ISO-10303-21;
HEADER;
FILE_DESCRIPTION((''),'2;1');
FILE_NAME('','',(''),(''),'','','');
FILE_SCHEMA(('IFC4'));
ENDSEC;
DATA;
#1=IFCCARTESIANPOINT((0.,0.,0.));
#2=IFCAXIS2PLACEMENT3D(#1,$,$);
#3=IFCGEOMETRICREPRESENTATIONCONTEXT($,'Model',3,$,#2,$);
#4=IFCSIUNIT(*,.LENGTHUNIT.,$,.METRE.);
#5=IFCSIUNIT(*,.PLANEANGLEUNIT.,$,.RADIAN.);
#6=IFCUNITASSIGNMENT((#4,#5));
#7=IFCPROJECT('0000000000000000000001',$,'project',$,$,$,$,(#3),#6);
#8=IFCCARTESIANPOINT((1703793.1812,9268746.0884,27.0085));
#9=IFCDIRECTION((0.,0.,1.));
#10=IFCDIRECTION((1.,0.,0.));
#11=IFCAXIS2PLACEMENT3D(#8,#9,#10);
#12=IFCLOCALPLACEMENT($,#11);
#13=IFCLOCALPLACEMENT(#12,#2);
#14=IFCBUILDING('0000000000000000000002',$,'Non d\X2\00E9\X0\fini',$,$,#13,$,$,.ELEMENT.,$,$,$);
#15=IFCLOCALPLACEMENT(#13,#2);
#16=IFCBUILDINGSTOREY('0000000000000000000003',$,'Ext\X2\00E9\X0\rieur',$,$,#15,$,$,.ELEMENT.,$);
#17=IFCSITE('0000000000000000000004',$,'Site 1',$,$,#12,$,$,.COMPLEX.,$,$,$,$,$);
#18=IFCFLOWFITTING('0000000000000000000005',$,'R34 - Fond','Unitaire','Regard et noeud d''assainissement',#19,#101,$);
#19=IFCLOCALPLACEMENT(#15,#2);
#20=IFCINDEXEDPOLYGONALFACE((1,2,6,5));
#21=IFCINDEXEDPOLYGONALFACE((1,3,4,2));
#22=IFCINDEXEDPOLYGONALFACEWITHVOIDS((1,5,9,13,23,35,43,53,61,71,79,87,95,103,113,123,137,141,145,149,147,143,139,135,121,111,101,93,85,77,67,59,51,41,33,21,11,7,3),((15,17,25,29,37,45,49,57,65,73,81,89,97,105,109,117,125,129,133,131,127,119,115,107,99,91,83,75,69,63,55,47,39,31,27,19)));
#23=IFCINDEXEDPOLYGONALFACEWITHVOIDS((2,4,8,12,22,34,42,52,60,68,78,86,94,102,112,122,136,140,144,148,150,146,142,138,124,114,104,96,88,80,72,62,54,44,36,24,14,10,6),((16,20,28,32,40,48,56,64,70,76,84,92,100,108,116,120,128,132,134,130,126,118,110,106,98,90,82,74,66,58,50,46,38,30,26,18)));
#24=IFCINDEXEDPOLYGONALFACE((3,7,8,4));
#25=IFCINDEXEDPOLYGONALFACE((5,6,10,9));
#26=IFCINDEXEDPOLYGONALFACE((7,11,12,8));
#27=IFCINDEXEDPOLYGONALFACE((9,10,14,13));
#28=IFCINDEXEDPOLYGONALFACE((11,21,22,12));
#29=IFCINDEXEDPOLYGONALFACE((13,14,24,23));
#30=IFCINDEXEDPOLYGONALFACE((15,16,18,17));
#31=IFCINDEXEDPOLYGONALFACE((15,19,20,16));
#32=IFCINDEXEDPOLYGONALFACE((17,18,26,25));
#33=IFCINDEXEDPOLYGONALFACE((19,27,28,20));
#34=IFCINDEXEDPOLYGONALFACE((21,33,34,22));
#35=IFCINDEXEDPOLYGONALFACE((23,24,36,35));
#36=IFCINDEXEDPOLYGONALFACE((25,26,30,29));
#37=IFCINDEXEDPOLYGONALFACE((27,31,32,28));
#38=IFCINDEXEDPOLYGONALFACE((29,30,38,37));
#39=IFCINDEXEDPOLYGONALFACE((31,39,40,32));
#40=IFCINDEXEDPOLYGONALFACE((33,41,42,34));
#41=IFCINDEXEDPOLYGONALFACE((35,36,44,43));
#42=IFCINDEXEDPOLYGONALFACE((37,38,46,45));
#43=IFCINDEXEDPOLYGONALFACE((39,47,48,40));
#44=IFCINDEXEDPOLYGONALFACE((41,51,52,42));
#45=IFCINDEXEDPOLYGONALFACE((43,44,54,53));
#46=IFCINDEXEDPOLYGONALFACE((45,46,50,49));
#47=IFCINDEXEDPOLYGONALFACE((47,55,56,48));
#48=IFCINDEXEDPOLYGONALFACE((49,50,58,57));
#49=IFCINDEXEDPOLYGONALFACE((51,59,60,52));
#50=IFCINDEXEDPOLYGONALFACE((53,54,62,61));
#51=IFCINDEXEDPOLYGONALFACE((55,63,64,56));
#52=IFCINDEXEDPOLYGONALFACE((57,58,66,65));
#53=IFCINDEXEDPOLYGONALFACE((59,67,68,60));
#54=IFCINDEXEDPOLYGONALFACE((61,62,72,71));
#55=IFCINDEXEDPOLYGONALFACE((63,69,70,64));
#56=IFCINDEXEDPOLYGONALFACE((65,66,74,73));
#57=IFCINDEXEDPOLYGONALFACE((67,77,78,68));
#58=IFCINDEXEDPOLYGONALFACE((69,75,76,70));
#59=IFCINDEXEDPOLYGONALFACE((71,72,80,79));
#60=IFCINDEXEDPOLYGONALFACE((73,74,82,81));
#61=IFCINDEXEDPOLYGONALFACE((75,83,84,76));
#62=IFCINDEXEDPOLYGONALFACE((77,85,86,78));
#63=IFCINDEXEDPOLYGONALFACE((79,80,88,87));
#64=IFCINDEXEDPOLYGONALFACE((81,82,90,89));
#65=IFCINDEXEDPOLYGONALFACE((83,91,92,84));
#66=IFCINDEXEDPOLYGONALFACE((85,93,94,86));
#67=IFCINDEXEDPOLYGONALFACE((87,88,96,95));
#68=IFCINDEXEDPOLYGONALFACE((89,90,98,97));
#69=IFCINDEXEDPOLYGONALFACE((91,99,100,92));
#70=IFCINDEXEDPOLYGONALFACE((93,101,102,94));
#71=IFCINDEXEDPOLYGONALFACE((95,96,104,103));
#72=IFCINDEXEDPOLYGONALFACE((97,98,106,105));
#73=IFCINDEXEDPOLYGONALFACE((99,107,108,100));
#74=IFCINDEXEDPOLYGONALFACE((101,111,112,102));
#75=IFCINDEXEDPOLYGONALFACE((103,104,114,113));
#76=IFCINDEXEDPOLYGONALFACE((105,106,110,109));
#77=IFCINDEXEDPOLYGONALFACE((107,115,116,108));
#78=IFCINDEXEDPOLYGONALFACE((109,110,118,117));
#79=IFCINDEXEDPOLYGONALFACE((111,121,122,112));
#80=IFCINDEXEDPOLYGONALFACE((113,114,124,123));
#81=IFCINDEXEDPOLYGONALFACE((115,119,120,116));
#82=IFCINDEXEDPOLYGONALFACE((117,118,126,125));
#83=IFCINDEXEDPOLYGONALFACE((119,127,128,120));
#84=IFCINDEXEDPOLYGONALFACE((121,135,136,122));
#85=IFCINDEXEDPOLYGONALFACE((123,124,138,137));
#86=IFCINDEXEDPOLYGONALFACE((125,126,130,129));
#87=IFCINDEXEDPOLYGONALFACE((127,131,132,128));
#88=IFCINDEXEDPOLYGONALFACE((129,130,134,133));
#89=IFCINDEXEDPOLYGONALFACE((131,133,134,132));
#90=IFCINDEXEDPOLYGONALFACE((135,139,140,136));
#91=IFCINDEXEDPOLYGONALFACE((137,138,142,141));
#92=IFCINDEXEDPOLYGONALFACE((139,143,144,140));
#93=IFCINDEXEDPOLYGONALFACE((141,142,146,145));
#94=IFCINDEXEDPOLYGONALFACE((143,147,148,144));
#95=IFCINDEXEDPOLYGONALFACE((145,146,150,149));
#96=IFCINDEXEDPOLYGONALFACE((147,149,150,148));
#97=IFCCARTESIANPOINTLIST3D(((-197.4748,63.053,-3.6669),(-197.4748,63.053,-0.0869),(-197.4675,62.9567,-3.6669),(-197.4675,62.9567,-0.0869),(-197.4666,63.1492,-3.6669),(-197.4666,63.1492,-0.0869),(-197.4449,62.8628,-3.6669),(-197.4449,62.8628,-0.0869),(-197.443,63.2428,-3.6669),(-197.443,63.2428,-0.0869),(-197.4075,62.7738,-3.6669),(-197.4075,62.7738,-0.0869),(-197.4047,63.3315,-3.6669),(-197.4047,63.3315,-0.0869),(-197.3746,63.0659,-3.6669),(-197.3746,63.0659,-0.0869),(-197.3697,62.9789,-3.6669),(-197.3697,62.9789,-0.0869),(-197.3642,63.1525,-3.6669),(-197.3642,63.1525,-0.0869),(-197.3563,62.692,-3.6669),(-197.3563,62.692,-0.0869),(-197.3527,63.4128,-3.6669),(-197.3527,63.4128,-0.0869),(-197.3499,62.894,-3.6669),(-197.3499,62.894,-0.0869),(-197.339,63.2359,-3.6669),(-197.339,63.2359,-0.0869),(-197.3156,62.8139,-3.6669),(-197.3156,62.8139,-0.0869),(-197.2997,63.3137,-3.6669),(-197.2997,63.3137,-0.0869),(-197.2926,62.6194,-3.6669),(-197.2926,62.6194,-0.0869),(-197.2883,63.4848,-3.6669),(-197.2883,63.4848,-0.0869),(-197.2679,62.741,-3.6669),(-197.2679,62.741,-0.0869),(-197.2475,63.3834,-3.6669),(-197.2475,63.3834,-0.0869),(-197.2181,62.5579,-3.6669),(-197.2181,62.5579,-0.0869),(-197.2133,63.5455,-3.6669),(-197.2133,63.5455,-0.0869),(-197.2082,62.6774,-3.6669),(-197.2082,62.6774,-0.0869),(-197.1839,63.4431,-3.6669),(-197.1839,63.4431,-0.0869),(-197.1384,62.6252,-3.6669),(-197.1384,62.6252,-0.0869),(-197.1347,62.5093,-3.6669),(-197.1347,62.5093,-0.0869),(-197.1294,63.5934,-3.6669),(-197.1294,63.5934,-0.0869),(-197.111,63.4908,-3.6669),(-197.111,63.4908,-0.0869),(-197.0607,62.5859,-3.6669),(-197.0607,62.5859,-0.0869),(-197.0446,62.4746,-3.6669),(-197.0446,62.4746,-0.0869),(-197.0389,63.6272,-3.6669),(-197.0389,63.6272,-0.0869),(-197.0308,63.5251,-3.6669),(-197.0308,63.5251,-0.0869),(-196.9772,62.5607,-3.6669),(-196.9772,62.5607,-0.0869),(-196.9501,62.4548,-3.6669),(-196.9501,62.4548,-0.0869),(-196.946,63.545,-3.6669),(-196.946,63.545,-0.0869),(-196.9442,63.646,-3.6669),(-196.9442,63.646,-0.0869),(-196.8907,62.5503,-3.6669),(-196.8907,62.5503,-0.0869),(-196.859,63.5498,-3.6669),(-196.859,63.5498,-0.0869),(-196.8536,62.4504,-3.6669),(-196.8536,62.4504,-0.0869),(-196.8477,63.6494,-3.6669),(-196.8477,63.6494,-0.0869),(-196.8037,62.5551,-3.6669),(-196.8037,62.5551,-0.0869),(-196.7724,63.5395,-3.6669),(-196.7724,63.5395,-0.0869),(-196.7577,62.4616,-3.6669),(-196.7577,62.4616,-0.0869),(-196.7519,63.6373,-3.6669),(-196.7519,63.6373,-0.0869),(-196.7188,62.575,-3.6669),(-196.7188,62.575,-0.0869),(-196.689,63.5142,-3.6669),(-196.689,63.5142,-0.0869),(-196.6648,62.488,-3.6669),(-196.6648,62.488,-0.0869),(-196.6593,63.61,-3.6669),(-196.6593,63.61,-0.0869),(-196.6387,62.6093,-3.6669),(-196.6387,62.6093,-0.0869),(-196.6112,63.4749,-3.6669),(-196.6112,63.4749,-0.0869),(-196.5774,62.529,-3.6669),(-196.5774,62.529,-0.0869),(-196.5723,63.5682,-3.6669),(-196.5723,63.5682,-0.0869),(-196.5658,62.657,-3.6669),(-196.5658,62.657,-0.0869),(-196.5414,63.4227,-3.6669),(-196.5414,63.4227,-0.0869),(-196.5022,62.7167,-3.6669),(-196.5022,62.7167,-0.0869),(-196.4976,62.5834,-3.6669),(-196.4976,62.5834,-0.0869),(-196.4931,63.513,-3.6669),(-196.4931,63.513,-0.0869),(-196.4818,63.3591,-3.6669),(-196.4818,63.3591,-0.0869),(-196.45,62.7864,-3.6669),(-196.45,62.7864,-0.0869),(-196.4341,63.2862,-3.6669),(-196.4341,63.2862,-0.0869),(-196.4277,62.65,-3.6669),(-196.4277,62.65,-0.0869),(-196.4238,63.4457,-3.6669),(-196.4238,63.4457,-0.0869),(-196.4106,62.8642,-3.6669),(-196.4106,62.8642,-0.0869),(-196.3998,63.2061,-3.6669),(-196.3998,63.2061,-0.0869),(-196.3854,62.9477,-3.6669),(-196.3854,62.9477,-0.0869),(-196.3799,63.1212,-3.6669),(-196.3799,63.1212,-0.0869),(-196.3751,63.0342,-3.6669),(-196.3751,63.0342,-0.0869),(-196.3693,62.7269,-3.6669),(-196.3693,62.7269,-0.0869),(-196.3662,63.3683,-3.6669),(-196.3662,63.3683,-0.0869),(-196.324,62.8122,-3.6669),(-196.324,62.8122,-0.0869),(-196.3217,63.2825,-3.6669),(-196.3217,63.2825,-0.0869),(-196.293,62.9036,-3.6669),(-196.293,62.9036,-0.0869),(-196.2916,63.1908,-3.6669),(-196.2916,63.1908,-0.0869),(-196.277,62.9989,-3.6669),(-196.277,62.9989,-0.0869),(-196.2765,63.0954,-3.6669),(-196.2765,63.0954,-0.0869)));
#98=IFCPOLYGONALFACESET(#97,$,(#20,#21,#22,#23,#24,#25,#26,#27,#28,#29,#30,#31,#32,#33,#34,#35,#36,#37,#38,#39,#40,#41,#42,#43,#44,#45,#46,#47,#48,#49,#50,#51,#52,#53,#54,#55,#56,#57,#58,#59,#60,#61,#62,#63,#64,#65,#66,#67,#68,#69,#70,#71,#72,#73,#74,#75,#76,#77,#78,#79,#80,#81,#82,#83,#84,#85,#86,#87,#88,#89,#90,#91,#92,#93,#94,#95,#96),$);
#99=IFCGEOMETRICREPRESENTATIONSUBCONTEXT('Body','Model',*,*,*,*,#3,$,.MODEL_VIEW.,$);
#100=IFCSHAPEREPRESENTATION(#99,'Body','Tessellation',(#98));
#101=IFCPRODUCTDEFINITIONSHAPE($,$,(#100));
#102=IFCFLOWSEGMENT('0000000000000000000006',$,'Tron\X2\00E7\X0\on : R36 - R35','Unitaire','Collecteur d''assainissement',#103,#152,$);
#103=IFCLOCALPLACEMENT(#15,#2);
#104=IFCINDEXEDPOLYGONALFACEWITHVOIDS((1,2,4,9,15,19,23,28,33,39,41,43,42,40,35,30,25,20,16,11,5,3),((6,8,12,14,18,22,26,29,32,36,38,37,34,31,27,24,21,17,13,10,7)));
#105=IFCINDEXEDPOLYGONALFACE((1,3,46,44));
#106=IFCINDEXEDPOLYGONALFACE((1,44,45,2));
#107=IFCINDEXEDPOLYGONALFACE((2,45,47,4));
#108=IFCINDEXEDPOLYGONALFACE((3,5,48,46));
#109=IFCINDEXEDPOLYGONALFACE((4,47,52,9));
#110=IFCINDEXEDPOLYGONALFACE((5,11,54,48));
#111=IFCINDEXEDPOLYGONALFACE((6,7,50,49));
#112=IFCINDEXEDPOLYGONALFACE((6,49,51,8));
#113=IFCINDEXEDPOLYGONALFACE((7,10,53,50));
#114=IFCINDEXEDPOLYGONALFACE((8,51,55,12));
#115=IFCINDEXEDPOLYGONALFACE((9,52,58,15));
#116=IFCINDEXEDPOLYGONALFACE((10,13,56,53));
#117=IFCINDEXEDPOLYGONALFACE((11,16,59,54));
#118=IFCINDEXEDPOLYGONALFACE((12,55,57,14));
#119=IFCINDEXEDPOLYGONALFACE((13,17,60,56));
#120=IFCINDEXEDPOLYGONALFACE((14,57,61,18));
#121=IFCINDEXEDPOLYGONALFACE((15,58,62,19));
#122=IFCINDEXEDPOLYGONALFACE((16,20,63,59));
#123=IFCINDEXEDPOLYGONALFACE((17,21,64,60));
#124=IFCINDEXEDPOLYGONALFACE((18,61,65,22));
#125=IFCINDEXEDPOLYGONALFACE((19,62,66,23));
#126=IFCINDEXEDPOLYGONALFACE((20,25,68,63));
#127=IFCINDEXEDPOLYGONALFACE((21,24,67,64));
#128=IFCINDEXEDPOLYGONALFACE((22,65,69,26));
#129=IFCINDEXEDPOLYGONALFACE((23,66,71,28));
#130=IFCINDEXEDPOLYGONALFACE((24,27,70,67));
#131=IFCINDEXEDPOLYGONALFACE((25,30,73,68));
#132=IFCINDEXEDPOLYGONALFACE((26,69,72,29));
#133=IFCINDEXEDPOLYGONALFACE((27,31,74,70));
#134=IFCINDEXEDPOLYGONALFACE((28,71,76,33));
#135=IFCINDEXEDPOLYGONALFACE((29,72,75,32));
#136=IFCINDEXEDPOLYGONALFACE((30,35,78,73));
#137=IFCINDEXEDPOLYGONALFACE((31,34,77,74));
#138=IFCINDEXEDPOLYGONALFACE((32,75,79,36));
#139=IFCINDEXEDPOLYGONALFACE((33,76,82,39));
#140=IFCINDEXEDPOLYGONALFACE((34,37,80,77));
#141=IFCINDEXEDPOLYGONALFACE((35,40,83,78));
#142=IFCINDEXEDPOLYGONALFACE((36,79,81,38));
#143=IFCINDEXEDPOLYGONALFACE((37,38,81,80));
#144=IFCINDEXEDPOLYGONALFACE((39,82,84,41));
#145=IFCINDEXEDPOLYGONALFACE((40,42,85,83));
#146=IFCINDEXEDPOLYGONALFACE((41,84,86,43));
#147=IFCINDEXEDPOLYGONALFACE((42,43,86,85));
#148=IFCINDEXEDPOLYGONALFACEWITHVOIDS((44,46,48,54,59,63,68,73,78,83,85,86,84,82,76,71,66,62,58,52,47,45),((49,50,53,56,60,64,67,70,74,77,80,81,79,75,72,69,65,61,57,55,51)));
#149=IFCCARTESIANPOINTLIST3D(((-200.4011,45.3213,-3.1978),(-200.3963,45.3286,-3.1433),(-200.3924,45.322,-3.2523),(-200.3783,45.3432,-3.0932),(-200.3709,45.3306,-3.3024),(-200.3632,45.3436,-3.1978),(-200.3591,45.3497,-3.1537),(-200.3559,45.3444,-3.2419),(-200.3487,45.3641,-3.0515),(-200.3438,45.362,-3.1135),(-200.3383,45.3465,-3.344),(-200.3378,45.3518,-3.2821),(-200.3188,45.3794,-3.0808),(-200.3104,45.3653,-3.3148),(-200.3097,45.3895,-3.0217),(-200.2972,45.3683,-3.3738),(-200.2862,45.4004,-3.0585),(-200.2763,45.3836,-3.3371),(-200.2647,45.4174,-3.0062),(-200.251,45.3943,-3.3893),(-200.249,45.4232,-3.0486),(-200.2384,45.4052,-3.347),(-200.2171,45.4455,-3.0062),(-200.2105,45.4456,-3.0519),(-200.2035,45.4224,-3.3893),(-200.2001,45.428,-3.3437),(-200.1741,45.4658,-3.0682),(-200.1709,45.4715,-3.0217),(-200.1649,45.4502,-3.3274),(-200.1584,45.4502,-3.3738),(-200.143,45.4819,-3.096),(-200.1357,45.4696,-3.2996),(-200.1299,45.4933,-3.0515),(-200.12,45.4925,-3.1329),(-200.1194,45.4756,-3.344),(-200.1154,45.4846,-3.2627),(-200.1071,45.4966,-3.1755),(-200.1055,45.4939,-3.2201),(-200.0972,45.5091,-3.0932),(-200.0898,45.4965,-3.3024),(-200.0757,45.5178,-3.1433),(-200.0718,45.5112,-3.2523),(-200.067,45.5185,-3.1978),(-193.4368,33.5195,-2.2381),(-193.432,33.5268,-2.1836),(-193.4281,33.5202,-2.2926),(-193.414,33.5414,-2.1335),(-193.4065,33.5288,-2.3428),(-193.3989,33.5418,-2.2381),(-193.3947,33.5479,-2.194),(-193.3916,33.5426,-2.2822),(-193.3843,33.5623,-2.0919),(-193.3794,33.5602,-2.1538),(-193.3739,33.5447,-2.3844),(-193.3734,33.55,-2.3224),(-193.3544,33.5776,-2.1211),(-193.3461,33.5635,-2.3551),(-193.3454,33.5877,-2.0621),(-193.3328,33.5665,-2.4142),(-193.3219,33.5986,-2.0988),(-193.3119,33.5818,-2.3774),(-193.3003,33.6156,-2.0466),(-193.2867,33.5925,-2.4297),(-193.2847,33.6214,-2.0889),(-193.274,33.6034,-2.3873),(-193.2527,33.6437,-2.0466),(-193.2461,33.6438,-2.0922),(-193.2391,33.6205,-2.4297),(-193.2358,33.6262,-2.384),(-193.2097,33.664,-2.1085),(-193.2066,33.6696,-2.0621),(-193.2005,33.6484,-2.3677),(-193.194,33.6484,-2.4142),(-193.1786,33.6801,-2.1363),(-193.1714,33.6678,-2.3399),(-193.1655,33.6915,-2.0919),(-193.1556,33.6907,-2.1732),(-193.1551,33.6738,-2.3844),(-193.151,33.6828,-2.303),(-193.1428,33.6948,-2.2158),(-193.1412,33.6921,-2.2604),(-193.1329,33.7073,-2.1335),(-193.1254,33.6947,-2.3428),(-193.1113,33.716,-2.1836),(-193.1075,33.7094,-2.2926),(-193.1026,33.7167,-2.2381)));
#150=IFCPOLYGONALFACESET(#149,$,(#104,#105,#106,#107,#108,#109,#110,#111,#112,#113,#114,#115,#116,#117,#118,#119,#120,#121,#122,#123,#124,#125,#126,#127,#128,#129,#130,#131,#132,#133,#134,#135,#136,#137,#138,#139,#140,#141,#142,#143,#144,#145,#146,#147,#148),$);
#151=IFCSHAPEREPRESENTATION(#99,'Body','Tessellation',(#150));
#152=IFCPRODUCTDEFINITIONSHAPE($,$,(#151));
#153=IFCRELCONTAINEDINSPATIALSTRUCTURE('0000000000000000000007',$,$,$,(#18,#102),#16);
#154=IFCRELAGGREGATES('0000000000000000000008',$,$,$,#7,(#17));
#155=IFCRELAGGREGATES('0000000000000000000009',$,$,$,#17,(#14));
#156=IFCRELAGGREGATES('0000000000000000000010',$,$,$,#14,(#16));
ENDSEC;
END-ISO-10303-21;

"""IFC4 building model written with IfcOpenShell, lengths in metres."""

from ifc_helpers import new_model, si_unit, frame, origin, origin_2d, place, context, subcontext, project, spatial, hollow_circle, extrude, element, save


model = new_model("IFC4")

# Units and contexts
model_context = context("Model", 3, world=origin())
body_context = subcontext(model_context, "Body", "Model", "MODEL_VIEW")
ifc_project = project(units=[si_unit("LENGTHUNIT", "METRE"), si_unit("PLANEANGLEUNIT", "RADIAN")], contexts=[model_context])

# Site, building, storey
site_placement = place(None, frame((1703793.1812, 9268746.0884, 27.0085), z_axis=(0.0, 0.0, 1.0), x_axis=(1.0, 0.0, 0.0)))
site = spatial("IfcSite", under=ifc_project, at=site_placement, Name="Site 1", CompositionType="COMPLEX")
building_placement = place(site_placement, origin())
building = spatial("IfcBuilding", under=site, at=building_placement, Name="Non défini", CompositionType="ELEMENT")
storey_placement = place(building_placement, origin())
storey = spatial("IfcBuildingStorey", under=building, at=storey_placement, Name="Extérieur", CompositionType="ELEMENT")

# Flow fitting
flow_fitting_1_placement = place(storey_placement, origin())
element("IfcFlowFitting", 1, at=flow_fitting_1_placement, inside=storey, Name="R34 - Fond", Description="Unitaire", ObjectType="Regard et noeud d'assainissement", context=body_context, shape_type="SweptSolid", body=[
    extrude(hollow_circle(Radius=0.6, WallThickness=0.1, at=origin_2d()), frame((-196.8748, 63.0501, -3.6669), z_axis=(0.0, 0.0, 1.0), x_axis=(0.204813, 0.978801, 0.0)), (0.0, 0.0, 1.0), 3.58),
])

# Flow segment
flow_segment_1_placement = place(storey_placement, origin())
element("IfcFlowSegment", 2, at=flow_segment_1_placement, inside=storey, Name="Tronçon : R36 - R35", Description="Unitaire", ObjectType="Collecteur d'assainissement", context=body_context, shape_type="SweptSolid", body=[
    extrude(hollow_circle(Radius=0.194, WallThickness=0.044, at=origin_2d()), frame((-193.2697, 33.6181, -2.2381), z_axis=(-0.506977, 0.859124, -0.069859), x_axis=(-0.861228, -0.508219, 0.0)), (0.0, 0.0, 1.0), 13.737),
])

save(model, "model.ifc")
